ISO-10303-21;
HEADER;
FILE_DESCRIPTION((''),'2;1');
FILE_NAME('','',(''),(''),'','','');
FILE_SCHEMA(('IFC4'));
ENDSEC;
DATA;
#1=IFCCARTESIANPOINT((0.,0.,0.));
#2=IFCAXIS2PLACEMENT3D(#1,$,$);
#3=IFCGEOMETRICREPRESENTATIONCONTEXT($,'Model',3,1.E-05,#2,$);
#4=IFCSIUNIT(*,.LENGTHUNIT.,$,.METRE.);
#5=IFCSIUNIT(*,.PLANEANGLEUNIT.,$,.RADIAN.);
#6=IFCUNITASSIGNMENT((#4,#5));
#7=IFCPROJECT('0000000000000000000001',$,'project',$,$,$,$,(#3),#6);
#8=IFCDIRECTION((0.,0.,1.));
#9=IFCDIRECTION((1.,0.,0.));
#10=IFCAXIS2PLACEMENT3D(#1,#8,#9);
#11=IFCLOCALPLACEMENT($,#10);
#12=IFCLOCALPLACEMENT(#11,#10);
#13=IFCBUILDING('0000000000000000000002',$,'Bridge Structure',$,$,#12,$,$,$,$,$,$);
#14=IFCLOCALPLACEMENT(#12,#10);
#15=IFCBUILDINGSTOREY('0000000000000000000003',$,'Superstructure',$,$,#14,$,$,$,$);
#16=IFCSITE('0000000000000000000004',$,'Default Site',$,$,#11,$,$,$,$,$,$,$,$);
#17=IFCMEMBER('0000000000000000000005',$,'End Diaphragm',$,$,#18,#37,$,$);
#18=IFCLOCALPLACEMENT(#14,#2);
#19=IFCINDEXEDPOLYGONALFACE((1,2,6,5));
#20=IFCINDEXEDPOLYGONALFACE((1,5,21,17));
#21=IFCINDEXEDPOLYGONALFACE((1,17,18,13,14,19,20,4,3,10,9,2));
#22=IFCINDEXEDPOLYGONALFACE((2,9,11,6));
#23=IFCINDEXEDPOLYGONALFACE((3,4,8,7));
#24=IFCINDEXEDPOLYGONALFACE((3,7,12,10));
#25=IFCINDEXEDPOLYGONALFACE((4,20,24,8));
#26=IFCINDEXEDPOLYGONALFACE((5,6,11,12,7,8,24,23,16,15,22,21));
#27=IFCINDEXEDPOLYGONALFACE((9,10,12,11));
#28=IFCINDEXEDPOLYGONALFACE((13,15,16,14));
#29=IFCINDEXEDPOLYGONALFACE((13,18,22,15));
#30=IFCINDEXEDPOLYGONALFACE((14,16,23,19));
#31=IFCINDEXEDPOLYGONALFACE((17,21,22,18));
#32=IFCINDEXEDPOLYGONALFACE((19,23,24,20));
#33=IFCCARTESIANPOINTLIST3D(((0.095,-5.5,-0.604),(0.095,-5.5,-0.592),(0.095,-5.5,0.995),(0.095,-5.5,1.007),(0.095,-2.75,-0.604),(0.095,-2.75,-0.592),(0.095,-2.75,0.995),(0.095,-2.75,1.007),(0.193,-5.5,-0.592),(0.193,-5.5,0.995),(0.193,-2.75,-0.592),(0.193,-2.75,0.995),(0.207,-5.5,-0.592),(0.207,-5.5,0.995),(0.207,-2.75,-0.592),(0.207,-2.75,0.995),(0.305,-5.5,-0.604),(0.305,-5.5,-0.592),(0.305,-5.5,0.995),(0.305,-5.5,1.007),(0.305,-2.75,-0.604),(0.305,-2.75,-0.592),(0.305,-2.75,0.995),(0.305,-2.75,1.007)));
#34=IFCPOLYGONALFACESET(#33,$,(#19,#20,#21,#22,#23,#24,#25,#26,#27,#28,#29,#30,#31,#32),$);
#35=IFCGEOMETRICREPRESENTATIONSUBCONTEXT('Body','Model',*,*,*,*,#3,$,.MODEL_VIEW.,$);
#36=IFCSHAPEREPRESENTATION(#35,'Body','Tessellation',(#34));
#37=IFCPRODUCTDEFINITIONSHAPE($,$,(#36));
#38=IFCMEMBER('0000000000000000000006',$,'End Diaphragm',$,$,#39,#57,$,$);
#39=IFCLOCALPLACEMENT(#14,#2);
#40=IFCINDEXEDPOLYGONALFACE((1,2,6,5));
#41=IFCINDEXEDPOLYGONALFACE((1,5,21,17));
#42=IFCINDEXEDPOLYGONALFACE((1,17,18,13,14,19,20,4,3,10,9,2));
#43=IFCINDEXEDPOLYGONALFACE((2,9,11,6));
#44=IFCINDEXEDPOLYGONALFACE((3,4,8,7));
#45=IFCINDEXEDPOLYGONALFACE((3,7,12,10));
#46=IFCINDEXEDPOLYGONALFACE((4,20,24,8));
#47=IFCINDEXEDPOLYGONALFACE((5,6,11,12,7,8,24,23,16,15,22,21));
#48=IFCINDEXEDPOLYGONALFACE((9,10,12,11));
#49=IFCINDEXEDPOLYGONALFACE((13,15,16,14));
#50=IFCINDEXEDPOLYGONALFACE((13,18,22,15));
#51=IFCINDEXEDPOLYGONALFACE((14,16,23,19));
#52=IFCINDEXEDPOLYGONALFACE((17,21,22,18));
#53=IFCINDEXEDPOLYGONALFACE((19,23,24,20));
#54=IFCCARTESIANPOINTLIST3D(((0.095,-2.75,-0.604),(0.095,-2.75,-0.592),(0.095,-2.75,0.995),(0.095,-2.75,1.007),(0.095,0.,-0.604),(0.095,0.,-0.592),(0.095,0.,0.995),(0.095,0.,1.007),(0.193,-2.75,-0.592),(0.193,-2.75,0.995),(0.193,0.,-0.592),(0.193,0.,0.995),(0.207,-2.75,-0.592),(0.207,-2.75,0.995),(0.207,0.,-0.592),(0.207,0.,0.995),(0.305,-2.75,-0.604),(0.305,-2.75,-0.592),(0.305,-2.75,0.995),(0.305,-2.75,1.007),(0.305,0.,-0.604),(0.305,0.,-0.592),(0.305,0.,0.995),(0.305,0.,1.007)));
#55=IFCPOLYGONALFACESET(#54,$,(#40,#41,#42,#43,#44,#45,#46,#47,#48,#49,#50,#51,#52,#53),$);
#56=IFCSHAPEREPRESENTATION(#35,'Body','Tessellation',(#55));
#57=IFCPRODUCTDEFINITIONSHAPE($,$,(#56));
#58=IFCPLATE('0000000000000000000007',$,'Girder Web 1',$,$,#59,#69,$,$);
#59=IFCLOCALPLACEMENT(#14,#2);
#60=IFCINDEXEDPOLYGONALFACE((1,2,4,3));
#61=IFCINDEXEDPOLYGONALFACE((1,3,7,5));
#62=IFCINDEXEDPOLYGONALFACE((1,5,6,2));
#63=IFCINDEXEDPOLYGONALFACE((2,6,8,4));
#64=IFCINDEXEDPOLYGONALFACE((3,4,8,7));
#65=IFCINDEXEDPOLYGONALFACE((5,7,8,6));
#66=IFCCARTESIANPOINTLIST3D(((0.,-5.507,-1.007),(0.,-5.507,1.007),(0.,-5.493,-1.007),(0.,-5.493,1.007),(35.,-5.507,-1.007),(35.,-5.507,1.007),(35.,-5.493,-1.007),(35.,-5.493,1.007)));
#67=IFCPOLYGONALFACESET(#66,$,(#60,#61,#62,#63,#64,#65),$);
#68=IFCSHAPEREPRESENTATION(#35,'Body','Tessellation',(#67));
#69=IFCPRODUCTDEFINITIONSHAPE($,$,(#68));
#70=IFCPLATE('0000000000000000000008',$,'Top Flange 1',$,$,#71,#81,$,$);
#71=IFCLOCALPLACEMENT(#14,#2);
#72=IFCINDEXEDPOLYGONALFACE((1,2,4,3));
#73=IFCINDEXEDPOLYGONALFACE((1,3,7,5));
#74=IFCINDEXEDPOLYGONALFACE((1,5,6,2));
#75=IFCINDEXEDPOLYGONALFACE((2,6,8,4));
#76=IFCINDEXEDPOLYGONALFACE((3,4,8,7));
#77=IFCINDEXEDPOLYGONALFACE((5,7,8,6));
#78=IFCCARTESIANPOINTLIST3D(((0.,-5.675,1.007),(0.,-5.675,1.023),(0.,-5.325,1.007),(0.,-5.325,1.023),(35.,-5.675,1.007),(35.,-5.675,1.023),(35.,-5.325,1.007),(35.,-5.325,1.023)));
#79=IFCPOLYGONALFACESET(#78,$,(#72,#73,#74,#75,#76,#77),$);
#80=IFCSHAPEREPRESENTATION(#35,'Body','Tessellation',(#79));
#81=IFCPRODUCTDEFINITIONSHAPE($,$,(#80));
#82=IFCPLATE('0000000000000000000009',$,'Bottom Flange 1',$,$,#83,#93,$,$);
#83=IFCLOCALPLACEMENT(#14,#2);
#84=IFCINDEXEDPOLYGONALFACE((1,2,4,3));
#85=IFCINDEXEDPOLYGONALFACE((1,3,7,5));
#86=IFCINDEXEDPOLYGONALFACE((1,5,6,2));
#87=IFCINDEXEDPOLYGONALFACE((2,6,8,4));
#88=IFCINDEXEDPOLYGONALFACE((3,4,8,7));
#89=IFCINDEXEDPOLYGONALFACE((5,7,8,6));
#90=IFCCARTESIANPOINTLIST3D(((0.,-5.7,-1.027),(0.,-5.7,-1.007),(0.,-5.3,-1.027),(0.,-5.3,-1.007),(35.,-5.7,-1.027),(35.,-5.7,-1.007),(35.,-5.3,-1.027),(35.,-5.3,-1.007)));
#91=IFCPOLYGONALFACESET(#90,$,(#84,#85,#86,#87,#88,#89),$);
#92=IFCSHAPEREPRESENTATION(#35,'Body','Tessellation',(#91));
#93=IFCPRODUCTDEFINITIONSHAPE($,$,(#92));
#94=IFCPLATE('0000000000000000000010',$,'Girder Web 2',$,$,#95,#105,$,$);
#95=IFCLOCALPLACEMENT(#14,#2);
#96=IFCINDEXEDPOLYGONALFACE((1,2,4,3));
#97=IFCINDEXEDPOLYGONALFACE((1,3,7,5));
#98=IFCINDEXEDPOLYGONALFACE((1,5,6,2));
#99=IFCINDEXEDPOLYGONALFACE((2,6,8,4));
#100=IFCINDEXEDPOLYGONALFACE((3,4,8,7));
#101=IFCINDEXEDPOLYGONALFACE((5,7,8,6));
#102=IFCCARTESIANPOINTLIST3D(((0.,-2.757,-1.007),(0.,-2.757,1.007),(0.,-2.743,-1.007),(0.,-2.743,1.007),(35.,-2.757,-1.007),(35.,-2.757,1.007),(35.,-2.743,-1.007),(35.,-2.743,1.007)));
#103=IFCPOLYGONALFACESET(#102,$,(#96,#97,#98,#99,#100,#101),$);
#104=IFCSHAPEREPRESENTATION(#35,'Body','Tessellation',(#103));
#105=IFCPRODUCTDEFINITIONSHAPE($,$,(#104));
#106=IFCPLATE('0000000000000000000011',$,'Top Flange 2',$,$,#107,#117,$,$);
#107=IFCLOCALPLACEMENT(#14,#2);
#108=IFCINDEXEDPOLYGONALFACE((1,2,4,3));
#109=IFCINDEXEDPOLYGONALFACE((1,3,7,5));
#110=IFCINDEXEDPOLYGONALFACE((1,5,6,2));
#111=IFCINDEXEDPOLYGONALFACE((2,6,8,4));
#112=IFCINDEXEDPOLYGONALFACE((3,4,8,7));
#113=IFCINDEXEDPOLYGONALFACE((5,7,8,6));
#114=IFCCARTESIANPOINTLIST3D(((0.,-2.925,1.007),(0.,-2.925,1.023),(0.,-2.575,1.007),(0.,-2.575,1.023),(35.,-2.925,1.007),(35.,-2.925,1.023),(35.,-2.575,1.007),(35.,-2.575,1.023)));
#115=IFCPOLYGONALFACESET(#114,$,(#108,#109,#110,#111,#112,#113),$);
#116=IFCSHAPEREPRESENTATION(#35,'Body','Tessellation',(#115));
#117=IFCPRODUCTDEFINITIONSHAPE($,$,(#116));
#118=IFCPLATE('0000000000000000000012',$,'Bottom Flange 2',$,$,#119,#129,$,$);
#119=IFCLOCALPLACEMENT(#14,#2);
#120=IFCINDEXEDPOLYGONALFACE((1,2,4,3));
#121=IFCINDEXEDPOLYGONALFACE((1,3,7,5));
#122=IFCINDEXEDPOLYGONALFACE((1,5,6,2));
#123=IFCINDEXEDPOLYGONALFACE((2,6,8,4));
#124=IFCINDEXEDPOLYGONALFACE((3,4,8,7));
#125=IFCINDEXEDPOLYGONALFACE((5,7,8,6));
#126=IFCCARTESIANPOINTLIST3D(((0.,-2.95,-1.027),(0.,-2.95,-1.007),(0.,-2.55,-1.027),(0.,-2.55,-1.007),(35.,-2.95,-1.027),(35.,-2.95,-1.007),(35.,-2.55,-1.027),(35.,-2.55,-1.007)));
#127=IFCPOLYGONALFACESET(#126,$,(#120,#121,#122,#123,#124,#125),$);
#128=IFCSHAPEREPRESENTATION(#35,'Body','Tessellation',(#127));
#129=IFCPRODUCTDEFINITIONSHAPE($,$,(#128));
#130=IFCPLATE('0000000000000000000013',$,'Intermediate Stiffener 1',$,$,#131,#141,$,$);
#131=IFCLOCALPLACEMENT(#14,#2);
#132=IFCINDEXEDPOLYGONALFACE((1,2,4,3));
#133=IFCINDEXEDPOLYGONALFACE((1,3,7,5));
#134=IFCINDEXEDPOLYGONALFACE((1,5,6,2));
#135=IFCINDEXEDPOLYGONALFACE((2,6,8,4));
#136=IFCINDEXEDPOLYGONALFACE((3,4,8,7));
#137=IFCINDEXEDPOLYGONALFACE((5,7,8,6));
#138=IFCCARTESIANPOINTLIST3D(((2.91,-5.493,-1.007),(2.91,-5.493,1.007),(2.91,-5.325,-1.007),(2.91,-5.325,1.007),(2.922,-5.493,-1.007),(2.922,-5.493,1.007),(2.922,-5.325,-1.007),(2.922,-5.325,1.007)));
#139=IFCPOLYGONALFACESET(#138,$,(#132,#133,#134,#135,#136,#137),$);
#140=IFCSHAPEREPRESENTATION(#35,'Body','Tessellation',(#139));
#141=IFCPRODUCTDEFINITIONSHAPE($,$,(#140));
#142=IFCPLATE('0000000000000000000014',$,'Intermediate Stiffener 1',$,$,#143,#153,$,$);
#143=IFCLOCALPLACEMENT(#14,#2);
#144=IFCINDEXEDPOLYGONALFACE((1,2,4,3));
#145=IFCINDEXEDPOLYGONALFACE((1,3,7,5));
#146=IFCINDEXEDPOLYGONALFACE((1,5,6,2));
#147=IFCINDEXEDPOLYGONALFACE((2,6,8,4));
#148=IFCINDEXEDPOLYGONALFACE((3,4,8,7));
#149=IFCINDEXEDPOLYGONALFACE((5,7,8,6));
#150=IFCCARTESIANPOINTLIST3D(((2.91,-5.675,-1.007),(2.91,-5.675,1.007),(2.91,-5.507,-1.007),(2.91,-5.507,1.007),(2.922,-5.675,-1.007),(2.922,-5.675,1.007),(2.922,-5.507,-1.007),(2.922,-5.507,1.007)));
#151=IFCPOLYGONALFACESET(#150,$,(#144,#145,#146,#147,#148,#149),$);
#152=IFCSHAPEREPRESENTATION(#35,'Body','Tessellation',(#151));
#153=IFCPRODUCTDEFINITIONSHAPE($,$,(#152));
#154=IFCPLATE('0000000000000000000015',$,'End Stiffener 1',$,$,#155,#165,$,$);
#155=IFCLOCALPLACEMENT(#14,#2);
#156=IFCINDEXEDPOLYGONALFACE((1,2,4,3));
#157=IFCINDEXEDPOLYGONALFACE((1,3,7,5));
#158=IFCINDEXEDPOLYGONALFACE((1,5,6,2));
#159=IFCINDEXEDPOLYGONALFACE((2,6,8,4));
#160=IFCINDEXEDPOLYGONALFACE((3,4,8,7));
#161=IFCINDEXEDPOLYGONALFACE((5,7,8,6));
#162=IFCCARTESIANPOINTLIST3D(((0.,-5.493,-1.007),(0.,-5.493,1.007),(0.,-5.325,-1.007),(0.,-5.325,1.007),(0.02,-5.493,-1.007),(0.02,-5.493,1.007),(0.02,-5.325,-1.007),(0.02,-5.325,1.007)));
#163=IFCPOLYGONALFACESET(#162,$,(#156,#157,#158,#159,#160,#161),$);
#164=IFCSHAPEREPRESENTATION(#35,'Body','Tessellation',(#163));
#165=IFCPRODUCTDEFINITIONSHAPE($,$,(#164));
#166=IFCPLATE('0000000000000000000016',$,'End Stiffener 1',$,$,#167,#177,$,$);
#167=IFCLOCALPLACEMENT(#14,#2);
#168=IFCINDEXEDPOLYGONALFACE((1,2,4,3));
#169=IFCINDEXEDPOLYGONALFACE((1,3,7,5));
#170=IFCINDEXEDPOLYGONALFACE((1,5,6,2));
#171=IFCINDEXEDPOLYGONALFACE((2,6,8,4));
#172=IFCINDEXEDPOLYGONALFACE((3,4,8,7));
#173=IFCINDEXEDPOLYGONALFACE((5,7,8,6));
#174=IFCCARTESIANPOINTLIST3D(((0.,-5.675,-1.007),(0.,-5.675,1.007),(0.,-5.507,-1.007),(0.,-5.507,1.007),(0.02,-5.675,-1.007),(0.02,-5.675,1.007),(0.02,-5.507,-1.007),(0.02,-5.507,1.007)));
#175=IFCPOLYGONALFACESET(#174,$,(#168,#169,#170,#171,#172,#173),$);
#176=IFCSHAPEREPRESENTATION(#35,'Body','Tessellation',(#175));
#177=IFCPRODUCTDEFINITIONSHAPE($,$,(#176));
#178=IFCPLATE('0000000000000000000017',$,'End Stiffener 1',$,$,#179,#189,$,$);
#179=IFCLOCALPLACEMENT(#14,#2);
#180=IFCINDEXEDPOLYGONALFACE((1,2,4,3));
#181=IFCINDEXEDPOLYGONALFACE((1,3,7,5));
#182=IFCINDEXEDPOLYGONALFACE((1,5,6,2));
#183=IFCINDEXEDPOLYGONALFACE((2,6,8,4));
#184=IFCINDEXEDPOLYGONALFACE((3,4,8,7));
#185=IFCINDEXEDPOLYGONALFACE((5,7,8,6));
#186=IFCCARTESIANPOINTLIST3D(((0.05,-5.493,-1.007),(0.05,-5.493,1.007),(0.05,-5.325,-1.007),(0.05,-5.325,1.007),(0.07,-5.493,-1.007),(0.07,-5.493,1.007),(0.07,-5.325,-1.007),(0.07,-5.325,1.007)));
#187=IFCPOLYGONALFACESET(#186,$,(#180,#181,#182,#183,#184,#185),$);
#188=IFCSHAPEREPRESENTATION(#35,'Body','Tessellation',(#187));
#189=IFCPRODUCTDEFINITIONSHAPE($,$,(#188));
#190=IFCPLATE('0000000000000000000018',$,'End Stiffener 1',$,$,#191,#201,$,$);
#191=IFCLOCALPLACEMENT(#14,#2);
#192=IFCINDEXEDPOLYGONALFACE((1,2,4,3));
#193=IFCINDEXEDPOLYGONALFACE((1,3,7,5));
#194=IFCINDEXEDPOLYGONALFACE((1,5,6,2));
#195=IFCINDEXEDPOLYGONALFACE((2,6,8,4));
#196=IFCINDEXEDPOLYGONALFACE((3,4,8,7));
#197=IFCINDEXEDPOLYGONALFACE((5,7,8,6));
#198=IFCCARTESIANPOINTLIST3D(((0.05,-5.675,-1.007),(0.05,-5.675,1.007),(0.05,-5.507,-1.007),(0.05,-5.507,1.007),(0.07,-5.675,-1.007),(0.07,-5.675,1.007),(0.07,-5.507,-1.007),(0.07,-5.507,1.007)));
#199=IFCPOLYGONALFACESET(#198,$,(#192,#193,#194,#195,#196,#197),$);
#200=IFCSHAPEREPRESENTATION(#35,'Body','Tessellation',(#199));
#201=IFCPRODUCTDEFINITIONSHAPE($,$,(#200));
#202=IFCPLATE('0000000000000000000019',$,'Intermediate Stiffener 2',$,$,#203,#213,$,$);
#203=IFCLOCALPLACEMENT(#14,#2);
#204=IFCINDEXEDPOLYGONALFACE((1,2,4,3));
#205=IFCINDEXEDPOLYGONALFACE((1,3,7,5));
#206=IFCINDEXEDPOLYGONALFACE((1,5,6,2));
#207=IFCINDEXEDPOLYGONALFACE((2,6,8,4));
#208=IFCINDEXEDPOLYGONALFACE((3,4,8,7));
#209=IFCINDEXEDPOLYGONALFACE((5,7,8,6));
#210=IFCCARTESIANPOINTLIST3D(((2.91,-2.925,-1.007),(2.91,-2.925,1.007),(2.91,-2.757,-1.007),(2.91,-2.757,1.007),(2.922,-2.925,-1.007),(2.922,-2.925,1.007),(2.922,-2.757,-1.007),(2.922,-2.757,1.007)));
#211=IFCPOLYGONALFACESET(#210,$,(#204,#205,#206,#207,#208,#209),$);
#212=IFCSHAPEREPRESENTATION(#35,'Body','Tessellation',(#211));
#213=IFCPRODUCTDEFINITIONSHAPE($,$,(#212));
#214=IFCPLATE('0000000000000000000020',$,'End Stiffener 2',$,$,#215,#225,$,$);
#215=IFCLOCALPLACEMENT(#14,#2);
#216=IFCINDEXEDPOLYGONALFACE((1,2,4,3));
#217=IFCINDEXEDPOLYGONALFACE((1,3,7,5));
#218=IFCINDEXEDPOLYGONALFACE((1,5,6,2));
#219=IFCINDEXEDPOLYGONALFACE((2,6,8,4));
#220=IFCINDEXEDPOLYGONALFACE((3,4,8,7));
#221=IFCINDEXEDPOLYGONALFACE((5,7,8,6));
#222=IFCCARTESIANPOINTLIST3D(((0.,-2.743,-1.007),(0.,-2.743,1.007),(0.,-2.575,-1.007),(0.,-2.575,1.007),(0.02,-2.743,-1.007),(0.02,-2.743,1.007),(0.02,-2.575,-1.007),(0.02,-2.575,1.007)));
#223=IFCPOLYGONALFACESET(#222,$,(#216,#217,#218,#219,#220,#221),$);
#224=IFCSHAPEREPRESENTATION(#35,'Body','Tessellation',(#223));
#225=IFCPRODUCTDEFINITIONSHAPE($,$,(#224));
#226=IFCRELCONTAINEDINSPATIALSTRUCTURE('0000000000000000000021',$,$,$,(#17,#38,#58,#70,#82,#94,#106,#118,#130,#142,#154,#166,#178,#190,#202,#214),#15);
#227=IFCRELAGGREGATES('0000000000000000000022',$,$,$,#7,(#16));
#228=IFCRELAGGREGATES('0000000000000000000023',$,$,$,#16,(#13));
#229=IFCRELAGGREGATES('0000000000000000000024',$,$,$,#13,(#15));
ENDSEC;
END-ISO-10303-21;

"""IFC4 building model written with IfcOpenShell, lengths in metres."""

from ifc_helpers import new_model, si_unit, frame, origin, origin_with_axes, origin_2d_with_axis, place, context, subcontext, project, spatial, rectangle, i_section, extrude, element, save


model = new_model("IFC4")

# Units and contexts
model_context = context("Model", 3, precision=1e-05, world=origin())
body_context = subcontext(model_context, "Body", "Model", "MODEL_VIEW")
ifc_project = project(units=[si_unit("LENGTHUNIT", "METRE"), si_unit("PLANEANGLEUNIT", "RADIAN")], contexts=[model_context])

# Site, building, storey
site_placement = place(None, origin_with_axes())
site = spatial("IfcSite", under=ifc_project, at=site_placement, Name="Default Site")
building_placement = place(site_placement, origin_with_axes())
building = spatial("IfcBuilding", under=site, at=building_placement, Name="Bridge Structure")
storey_placement = place(building_placement, origin_with_axes())
storey = spatial("IfcBuildingStorey", under=building, at=storey_placement, Name="Superstructure")

# Members
for number, where, z_axis, x_axis, name in (
    (1, (0.2, -5.5, 0.2015), (0.0, 1.0, 0.0), (-1.0, 0.0, 0.0), "End Diaphragm"),
    (2, (0.2, -2.75, 0.2015), (0.0, 1.0, 0.0), (-1.0, 0.0, 0.0), "End Diaphragm"),
):
    element("IfcMember", number, at=place(storey_placement, frame(where, z_axis=z_axis, x_axis=x_axis)), inside=storey, Name=name, context=body_context, shape_type="SweptSolid", body=[
        extrude(i_section(OverallWidth=0.21, OverallDepth=1.611, WebThickness=0.014, FlangeThickness=0.012, at=origin_2d_with_axis()), origin_with_axes(), (0.0, 0.0, 1.0), 2.75),
    ])

# Plates
plate_1_placement = place(storey_placement, frame((0.0, -5.5, 0.0), z_axis=(1.0, 0.0, 0.0), x_axis=(0.0, 1.0, 0.0)))
element("IfcPlate", 3, at=plate_1_placement, inside=storey, Name="Girder Web 1", context=body_context, shape_type="SweptSolid", body=[
    extrude(rectangle(XDim=0.014, YDim=2.014, at=origin_2d_with_axis()), origin_with_axes(), (0.0, 0.0, 1.0), 35.0),
])
plate_2_placement = place(storey_placement, frame((0.0, -5.5, 1.015), z_axis=(1.0, 0.0, 0.0), x_axis=(0.0, 1.0, 0.0)))
element("IfcPlate", 4, at=plate_2_placement, inside=storey, Name="Top Flange 1", context=body_context, shape_type="SweptSolid", body=[
    extrude(rectangle(XDim=0.35, YDim=0.016, at=origin_2d_with_axis()), origin_with_axes(), (0.0, 0.0, 1.0), 35.0),
])
plate_3_placement = place(storey_placement, frame((0.0, -5.5, -1.017), z_axis=(1.0, 0.0, 0.0), x_axis=(0.0, 1.0, 0.0)))
element("IfcPlate", 5, at=plate_3_placement, inside=storey, Name="Bottom Flange 1", context=body_context, shape_type="SweptSolid", body=[
    extrude(rectangle(XDim=0.4, YDim=0.02, at=origin_2d_with_axis()), origin_with_axes(), (0.0, 0.0, 1.0), 35.0),
])
plate_4_placement = place(storey_placement, frame((0.0, -2.75, 0.0), z_axis=(1.0, 0.0, 0.0), x_axis=(0.0, 1.0, 0.0)))
element("IfcPlate", 6, at=plate_4_placement, inside=storey, Name="Girder Web 2", context=body_context, shape_type="SweptSolid", body=[
    extrude(rectangle(XDim=0.014, YDim=2.014, at=origin_2d_with_axis()), origin_with_axes(), (0.0, 0.0, 1.0), 35.0),
])
plate_5_placement = place(storey_placement, frame((0.0, -2.75, 1.015), z_axis=(1.0, 0.0, 0.0), x_axis=(0.0, 1.0, 0.0)))
element("IfcPlate", 7, at=plate_5_placement, inside=storey, Name="Top Flange 2", context=body_context, shape_type="SweptSolid", body=[
    extrude(rectangle(XDim=0.35, YDim=0.016, at=origin_2d_with_axis()), origin_with_axes(), (0.0, 0.0, 1.0), 35.0),
])
plate_6_placement = place(storey_placement, frame((0.0, -2.75, -1.017), z_axis=(1.0, 0.0, 0.0), x_axis=(0.0, 1.0, 0.0)))
element("IfcPlate", 8, at=plate_6_placement, inside=storey, Name="Bottom Flange 2", context=body_context, shape_type="SweptSolid", body=[
    extrude(rectangle(XDim=0.4, YDim=0.02, at=origin_2d_with_axis()), origin_with_axes(), (0.0, 0.0, 1.0), 35.0),
])
for number, where, z_axis, x_axis, name in (
    (9, (2.916, -5.409, -1.007), (0.0, 0.0, 1.0), (1.0, 0.0, 0.0), "Intermediate Stiffener 1"),
    (10, (2.916, -5.591, -1.007), (0.0, 0.0, 1.0), (1.0, 0.0, 0.0), "Intermediate Stiffener 1"),
):
    element("IfcPlate", number, at=place(storey_placement, frame(where, z_axis=z_axis, x_axis=x_axis)), inside=storey, Name=name, context=body_context, shape_type="SweptSolid", body=[
        extrude(rectangle(XDim=0.012, YDim=0.168, at=origin_2d_with_axis()), origin_with_axes(), (0.0, 0.0, 1.0), 2.014),
    ])
for number, where, z_axis, x_axis, name in (
    (11, (0.01, -5.409, -1.007), (0.0, 0.0, 1.0), (1.0, 0.0, 0.0), "End Stiffener 1"),
    (12, (0.01, -5.591, -1.007), (0.0, 0.0, 1.0), (1.0, 0.0, 0.0), "End Stiffener 1"),
    (13, (0.06, -5.409, -1.007), (0.0, 0.0, 1.0), (1.0, 0.0, 0.0), "End Stiffener 1"),
    (14, (0.06, -5.591, -1.007), (0.0, 0.0, 1.0), (1.0, 0.0, 0.0), "End Stiffener 1"),
):
    element("IfcPlate", number, at=place(storey_placement, frame(where, z_axis=z_axis, x_axis=x_axis)), inside=storey, Name=name, context=body_context, shape_type="SweptSolid", body=[
        extrude(rectangle(XDim=0.02, YDim=0.168, at=origin_2d_with_axis()), origin_with_axes(), (0.0, 0.0, 1.0), 2.014),
    ])
plate_7_placement = place(storey_placement, frame((2.916, -2.841, -1.007), z_axis=(0.0, 0.0, 1.0), x_axis=(1.0, 0.0, 0.0)))
element("IfcPlate", 15, at=plate_7_placement, inside=storey, Name="Intermediate Stiffener 2", context=body_context, shape_type="SweptSolid", body=[
    extrude(rectangle(XDim=0.012, YDim=0.168, at=origin_2d_with_axis()), origin_with_axes(), (0.0, 0.0, 1.0), 2.014),
])
for number, where, z_axis, x_axis, name in (
    (16, (0.01, -2.659, -1.007), (0.0, 0.0, 1.0), (1.0, 0.0, 0.0), "End Stiffener 2"),
):
    element("IfcPlate", number, at=place(storey_placement, frame(where, z_axis=z_axis, x_axis=x_axis)), inside=storey, Name=name, context=body_context, shape_type="SweptSolid", body=[
        extrude(rectangle(XDim=0.02, YDim=0.168, at=origin_2d_with_axis()), origin_with_axes(), (0.0, 0.0, 1.0), 2.014),
    ])

save(model, "model.ifc")
